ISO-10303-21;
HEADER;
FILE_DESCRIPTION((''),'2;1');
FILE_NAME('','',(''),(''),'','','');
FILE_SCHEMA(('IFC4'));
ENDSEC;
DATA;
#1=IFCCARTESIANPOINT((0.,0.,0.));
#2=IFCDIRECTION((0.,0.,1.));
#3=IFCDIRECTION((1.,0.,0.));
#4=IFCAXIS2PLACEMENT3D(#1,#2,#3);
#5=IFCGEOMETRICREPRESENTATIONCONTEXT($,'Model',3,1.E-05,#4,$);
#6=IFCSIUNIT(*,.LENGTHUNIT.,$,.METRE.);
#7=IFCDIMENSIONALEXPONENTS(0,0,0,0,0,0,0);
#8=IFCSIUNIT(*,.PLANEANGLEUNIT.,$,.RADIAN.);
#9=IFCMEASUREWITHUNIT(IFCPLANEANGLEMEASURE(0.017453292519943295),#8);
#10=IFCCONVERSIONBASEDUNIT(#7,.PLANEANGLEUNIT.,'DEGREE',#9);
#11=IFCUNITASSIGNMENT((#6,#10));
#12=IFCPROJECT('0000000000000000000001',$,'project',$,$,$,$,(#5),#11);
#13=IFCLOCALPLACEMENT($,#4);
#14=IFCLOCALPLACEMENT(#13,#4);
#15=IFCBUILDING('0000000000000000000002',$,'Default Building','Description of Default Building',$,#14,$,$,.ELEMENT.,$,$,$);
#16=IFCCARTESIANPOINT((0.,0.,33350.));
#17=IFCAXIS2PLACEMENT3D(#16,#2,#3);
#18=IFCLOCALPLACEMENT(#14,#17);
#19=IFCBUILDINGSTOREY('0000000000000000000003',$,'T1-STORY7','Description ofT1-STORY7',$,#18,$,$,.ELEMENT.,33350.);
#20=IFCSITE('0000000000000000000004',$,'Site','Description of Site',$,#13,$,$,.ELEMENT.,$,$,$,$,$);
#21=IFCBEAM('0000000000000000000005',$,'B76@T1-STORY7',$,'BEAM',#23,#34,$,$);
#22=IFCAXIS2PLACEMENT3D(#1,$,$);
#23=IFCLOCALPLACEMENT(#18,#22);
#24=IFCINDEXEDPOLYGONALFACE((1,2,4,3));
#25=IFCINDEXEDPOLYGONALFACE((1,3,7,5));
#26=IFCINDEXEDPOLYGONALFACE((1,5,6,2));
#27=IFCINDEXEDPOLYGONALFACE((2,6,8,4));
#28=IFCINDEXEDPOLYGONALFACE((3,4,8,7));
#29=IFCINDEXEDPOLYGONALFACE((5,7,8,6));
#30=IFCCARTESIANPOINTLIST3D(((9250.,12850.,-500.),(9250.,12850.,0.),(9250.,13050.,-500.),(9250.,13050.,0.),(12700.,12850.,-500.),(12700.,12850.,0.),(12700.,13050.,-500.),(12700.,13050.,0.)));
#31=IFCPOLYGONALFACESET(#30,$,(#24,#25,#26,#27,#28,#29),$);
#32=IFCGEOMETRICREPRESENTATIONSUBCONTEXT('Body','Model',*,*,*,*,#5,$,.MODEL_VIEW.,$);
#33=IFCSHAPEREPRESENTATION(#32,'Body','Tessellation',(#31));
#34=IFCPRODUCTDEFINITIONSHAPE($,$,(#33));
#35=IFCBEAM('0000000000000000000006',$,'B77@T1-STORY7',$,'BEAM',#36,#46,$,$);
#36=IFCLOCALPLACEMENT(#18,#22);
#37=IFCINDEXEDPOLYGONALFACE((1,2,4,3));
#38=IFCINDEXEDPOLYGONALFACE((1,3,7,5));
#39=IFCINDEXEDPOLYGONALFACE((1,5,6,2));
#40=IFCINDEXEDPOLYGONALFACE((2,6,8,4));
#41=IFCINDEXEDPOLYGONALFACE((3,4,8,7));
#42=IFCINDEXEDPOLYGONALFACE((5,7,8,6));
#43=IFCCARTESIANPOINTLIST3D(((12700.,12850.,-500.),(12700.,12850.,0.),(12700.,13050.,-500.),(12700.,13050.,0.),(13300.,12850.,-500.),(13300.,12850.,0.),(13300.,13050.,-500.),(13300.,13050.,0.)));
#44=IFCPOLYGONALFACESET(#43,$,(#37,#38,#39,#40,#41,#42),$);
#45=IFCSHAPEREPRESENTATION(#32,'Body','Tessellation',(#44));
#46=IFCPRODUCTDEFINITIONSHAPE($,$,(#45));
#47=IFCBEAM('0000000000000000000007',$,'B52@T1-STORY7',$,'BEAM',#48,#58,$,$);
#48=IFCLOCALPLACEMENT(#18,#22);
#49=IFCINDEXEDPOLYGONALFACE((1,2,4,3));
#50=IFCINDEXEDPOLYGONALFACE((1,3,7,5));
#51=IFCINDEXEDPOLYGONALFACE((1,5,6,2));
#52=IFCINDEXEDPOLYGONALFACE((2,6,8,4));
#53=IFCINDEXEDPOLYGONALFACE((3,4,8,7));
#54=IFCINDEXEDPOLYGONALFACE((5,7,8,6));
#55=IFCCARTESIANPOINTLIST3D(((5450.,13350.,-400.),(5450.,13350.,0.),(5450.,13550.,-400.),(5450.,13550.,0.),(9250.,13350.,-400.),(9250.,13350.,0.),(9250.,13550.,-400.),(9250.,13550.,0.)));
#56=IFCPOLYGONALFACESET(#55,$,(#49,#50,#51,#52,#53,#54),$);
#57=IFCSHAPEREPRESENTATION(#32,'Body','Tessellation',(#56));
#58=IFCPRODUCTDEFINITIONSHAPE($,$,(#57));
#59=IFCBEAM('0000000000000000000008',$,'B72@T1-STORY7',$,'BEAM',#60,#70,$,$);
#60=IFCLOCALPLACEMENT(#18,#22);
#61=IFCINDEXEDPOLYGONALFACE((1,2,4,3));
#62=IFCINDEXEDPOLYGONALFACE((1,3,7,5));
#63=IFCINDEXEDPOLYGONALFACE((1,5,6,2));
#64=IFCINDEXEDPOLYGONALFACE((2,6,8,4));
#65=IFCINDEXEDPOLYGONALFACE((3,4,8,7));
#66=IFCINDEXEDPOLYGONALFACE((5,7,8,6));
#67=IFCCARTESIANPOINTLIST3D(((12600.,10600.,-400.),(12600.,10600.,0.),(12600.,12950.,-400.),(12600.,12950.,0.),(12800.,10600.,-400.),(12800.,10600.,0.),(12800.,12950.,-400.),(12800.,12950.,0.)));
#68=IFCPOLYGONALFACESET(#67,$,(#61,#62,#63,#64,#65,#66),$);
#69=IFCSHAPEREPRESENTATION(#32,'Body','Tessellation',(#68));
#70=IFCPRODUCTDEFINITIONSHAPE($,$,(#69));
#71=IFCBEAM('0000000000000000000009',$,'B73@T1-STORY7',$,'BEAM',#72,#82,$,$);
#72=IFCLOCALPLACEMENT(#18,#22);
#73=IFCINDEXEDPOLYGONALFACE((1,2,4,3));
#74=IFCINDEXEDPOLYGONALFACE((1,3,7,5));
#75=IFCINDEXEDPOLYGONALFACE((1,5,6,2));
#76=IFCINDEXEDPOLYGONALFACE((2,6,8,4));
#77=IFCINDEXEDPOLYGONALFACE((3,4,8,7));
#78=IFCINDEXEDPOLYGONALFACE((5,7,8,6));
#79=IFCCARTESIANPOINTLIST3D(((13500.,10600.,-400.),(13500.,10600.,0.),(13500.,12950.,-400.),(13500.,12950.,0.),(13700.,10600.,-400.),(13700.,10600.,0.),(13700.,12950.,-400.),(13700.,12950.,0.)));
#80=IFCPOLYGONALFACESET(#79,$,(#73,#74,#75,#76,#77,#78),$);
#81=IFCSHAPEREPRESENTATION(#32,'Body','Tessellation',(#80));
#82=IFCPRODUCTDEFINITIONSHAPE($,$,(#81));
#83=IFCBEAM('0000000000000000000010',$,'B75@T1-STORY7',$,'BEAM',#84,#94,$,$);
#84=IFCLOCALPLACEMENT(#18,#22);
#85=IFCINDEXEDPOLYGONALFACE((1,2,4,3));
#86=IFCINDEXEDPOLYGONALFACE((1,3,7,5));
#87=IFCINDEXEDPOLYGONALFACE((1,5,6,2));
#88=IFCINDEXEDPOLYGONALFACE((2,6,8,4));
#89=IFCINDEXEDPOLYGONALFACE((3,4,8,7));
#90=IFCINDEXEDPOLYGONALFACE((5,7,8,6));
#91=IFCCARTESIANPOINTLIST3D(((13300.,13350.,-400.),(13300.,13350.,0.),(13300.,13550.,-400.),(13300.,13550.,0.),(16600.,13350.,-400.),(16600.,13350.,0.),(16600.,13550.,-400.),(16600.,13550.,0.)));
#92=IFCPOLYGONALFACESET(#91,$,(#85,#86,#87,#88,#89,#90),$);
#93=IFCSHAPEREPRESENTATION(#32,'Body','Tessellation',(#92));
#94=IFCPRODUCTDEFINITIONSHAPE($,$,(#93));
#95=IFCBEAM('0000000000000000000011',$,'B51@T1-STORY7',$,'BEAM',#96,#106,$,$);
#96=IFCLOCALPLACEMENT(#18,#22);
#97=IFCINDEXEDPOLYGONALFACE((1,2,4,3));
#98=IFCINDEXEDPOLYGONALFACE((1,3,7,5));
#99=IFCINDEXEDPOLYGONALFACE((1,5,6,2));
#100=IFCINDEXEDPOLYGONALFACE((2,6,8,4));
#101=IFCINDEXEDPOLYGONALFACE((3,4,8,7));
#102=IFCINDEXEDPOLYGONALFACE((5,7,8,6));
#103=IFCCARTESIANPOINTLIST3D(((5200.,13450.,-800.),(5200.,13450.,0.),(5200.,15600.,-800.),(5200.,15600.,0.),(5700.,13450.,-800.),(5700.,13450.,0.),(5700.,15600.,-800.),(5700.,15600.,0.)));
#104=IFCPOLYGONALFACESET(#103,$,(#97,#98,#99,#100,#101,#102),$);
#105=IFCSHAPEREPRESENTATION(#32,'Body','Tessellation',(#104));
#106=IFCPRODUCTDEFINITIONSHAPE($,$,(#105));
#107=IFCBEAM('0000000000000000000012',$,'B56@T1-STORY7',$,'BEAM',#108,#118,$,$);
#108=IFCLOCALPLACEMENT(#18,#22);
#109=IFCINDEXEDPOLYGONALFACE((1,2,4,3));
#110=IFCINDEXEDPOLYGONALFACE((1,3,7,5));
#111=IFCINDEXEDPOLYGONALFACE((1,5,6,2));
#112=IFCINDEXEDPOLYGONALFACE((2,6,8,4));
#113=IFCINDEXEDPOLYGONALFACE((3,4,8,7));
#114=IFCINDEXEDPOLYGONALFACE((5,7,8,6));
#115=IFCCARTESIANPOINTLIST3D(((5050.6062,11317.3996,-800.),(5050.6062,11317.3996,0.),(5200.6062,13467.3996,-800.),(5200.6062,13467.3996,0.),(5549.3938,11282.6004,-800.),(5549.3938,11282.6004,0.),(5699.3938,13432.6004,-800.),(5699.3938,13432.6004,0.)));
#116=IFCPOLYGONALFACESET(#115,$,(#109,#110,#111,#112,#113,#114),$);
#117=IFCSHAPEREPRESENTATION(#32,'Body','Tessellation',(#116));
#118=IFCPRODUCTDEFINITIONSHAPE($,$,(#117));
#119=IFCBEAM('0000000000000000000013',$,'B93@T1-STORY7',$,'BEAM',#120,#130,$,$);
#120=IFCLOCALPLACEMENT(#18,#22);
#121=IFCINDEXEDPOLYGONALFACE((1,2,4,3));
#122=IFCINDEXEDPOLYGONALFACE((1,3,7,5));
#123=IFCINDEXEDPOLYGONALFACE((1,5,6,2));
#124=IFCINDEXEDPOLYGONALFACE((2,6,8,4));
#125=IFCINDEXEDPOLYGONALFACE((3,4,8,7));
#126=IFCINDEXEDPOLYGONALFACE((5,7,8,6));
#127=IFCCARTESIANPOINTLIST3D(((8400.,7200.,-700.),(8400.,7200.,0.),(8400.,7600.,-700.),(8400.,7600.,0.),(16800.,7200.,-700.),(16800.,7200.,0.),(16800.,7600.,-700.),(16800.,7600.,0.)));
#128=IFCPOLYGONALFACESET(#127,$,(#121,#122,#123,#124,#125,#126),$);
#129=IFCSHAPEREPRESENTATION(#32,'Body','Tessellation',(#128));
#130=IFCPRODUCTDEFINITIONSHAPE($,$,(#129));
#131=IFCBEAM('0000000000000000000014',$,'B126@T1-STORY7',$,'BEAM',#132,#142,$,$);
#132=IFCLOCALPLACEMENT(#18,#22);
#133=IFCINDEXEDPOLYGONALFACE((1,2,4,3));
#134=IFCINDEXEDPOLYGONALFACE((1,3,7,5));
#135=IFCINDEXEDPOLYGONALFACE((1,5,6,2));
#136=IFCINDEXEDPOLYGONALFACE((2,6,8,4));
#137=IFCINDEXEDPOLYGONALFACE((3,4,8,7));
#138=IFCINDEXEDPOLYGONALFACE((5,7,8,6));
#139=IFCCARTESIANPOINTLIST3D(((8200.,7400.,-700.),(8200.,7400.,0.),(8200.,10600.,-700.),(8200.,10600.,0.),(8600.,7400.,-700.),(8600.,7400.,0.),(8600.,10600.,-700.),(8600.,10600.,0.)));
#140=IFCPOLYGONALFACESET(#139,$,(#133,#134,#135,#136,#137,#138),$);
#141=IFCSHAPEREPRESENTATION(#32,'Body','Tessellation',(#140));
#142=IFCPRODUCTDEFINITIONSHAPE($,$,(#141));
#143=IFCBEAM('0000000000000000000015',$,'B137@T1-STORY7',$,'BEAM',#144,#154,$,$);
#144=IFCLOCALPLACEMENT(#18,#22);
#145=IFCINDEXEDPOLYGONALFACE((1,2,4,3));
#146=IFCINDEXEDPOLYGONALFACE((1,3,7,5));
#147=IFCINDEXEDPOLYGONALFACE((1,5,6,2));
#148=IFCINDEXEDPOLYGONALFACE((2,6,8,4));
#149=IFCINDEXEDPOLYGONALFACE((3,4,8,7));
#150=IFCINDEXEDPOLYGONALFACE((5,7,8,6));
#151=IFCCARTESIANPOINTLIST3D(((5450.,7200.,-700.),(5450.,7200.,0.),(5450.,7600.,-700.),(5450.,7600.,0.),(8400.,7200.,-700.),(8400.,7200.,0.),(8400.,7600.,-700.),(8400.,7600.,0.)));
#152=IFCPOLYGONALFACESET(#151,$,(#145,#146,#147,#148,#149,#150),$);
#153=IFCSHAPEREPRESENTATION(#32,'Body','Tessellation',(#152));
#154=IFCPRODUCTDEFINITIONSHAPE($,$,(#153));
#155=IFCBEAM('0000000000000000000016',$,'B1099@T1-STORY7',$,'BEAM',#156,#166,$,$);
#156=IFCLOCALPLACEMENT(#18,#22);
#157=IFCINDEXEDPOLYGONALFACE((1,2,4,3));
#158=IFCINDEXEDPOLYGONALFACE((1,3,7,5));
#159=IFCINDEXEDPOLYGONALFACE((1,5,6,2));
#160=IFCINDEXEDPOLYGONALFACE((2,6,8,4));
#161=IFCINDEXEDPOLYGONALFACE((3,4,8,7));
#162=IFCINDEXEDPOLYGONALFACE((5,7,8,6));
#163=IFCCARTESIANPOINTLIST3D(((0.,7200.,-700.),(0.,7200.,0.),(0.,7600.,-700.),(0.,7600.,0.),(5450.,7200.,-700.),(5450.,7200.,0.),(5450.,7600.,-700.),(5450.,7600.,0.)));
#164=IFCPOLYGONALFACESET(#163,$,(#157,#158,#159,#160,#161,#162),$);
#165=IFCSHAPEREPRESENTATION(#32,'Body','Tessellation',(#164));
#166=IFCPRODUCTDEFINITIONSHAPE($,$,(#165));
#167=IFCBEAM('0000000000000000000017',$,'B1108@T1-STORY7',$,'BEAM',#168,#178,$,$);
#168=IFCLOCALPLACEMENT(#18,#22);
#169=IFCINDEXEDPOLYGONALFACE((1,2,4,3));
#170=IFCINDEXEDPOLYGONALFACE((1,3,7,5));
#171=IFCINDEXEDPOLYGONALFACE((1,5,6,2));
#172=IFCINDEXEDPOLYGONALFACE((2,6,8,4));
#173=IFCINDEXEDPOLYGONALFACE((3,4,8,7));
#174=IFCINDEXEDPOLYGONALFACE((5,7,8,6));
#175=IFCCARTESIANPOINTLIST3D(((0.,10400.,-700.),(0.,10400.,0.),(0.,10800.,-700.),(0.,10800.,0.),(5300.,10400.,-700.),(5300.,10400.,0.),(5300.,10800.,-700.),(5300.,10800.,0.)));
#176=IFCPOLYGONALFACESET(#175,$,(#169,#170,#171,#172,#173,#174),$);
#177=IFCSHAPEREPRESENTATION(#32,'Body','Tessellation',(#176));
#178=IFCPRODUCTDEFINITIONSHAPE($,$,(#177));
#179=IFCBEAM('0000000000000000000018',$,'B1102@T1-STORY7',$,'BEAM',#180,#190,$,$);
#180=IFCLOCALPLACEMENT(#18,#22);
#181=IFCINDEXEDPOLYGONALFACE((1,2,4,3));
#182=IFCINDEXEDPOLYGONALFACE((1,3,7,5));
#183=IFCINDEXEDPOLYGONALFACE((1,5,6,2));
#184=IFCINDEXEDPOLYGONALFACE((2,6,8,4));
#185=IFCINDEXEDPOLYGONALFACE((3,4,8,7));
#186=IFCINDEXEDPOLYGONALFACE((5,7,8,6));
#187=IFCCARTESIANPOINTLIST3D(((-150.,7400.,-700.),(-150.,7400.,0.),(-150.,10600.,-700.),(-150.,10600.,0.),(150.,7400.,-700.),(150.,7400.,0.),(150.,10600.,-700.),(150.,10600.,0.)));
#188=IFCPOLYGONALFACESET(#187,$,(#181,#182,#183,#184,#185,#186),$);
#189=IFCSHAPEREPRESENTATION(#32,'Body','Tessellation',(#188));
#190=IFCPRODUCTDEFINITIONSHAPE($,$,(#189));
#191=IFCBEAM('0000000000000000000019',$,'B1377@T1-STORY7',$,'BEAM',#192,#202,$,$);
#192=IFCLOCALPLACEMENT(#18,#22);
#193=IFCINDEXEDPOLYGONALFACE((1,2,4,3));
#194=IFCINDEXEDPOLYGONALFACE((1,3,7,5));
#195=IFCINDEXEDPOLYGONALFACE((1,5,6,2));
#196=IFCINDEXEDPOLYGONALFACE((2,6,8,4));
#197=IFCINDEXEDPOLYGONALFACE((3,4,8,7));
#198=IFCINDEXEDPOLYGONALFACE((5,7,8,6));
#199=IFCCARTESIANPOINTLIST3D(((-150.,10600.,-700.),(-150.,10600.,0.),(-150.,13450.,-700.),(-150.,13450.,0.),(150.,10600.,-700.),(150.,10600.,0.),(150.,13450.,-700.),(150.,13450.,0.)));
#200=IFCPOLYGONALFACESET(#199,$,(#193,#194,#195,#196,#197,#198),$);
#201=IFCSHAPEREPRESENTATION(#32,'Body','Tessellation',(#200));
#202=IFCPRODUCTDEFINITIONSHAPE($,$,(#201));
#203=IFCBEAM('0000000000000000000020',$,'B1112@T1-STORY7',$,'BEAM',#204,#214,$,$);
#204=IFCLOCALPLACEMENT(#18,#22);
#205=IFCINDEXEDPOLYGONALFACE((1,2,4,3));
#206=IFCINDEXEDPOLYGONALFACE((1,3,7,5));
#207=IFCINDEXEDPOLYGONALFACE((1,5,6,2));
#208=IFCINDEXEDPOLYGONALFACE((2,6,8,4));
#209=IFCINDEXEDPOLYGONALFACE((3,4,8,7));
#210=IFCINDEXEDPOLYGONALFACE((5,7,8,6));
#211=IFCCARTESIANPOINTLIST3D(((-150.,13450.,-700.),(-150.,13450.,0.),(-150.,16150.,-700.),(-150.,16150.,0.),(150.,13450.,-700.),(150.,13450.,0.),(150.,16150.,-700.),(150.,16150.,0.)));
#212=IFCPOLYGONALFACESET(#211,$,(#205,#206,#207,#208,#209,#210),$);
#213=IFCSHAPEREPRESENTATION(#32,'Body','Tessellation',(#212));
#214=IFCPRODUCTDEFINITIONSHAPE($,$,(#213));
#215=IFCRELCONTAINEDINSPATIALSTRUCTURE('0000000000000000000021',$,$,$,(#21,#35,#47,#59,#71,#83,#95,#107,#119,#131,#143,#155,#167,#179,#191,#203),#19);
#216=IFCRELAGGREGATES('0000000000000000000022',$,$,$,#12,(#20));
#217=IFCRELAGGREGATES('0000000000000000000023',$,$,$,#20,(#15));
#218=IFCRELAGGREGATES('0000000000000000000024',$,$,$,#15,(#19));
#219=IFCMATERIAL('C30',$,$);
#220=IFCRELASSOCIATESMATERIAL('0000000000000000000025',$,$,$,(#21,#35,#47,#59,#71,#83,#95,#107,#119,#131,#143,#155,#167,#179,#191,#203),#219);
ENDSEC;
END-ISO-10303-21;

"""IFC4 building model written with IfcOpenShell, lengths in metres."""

from ifc_helpers import new_model, entity, si_unit, converted_unit, frame, origin_with_axes, place, context, subcontext, project, spatial, rectangle, extrude, material, element, save


model = new_model("IFC4")

# Units and contexts
model_context = context("Model", 3, precision=1e-05, world=origin_with_axes())
body_context = subcontext(model_context, "Body", "Model", "MODEL_VIEW")
ifc_project = project(units=[si_unit("LENGTHUNIT", "METRE"), converted_unit("PLANEANGLEUNIT", "DEGREE", entity("IfcPlaneAngleMeasure", 0.017453292519943295), si_unit("PLANEANGLEUNIT", "RADIAN"), dimensions=[0, 0, 0, 0, 0, 0, 0])], contexts=[model_context])

# Site, building, storey
site_placement = place(None, origin_with_axes())
site = spatial("IfcSite", under=ifc_project, at=site_placement, Name="Site", Description="Description of Site", CompositionType="ELEMENT")
building_placement = place(site_placement, origin_with_axes())
building = spatial("IfcBuilding", under=site, at=building_placement, Name="Default Building", Description="Description of Default Building", CompositionType="ELEMENT")
storey_placement = place(building_placement, frame((0.0, 0.0, 33350.0), z_axis=(0.0, 0.0, 1.0), x_axis=(1.0, 0.0, 0.0)))
storey = spatial("IfcBuildingStorey", under=building, at=storey_placement, Name="T1-STORY7", Description="Description ofT1-STORY7", CompositionType="ELEMENT", Elevation=33350.0)

# Beams
ifc_material_1 = material(Name="C30")
beam_1_placement = place(storey_placement, frame((9250.0, 12950.0, -250.0), z_axis=(1.0, 0.0, 0.0), x_axis=(0.0, 1.0, 0.0)))
element("IfcBeam", 1, at=beam_1_placement, inside=storey, material=ifc_material_1, Name="B76@T1-STORY7", ObjectType="BEAM", context=body_context, shape_type="SweptSolid", body=[
    extrude(rectangle(XDim=200.0, YDim=500.0), origin_with_axes(), (0.0, 0.0, 1.0), 3450.0),
])
beam_2_placement = place(storey_placement, frame((12700.0, 12950.0, -250.0), z_axis=(1.0, 0.0, 0.0), x_axis=(0.0, 1.0, 0.0)))
element("IfcBeam", 2, at=beam_2_placement, inside=storey, material=ifc_material_1, Name="B77@T1-STORY7", ObjectType="BEAM", context=body_context, shape_type="SweptSolid", body=[
    extrude(rectangle(XDim=200.0, YDim=500.0), origin_with_axes(), (0.0, 0.0, 1.0), 600.0),
])
beam_3_placement = place(storey_placement, frame((5450.0, 13450.0, -200.0), z_axis=(1.0, 0.0, 0.0), x_axis=(0.0, 1.0, 0.0)))
element("IfcBeam", 3, at=beam_3_placement, inside=storey, material=ifc_material_1, Name="B52@T1-STORY7", ObjectType="BEAM", context=body_context, shape_type="SweptSolid", body=[
    extrude(rectangle(XDim=200.0, YDim=400.0), origin_with_axes(), (0.0, 0.0, 1.0), 3800.0),
])
for number, where, z_axis, x_axis, name in (
    (4, (12700.0, 10600.0, -200.0), (0.0, 1.0, 0.0), (-1.0, 0.0, 0.0), "B72@T1-STORY7"),
    (5, (13600.0, 10600.0, -200.0), (0.0, 1.0, 0.0), (-1.0, 0.0, 0.0), "B73@T1-STORY7"),
):
    element("IfcBeam", number, at=place(storey_placement, frame(where, z_axis=z_axis, x_axis=x_axis)), inside=storey, material=ifc_material_1, Name=name, ObjectType="BEAM", context=body_context, shape_type="SweptSolid", body=[
        extrude(rectangle(XDim=200.0, YDim=400.0), origin_with_axes(), (0.0, 0.0, 1.0), 2350.0),
    ])
beam_4_placement = place(storey_placement, frame((13300.0, 13450.0, -200.0), z_axis=(1.0, 0.0, 0.0), x_axis=(0.0, 1.0, 0.0)))
element("IfcBeam", 6, at=beam_4_placement, inside=storey, material=ifc_material_1, Name="B75@T1-STORY7", ObjectType="BEAM", context=body_context, shape_type="SweptSolid", body=[
    extrude(rectangle(XDim=200.0, YDim=400.0), origin_with_axes(), (0.0, 0.0, 1.0), 3300.0),
])
beam_5_placement = place(storey_placement, frame((5450.0, 13450.0, -400.0), z_axis=(0.0, 1.0, 0.0), x_axis=(-1.0, 0.0, 0.0)))
element("IfcBeam", 7, at=beam_5_placement, inside=storey, material=ifc_material_1, Name="B51@T1-STORY7", ObjectType="BEAM", context=body_context, shape_type="SweptSolid", body=[
    extrude(rectangle(XDim=500.0, YDim=800.0), origin_with_axes(), (0.0, 0.0, 1.0), 2150.0),
])
beam_6_placement = place(storey_placement, frame((5300.0, 11300.0, -400.0), z_axis=(0.069598, 0.997575, 0.0), x_axis=(-0.997575, 0.069598, 0.0)))
element("IfcBeam", 8, at=beam_6_placement, inside=storey, material=ifc_material_1, Name="B56@T1-STORY7", ObjectType="BEAM", context=body_context, shape_type="SweptSolid", body=[
    extrude(rectangle(XDim=500.0, YDim=800.0), origin_with_axes(), (0.0, 0.0, 1.0), 2155.2262),
])
beam_7_placement = place(storey_placement, frame((8400.0, 7400.0, -350.0), z_axis=(1.0, 0.0, 0.0), x_axis=(0.0, 1.0, 0.0)))
element("IfcBeam", 9, at=beam_7_placement, inside=storey, material=ifc_material_1, Name="B93@T1-STORY7", ObjectType="BEAM", context=body_context, shape_type="SweptSolid", body=[
    extrude(rectangle(XDim=400.0, YDim=700.0), origin_with_axes(), (0.0, 0.0, 1.0), 8400.0),
])
beam_8_placement = place(storey_placement, frame((8400.0, 7400.0, -350.0), z_axis=(0.0, 1.0, 0.0), x_axis=(-1.0, 0.0, 0.0)))
element("IfcBeam", 10, at=beam_8_placement, inside=storey, material=ifc_material_1, Name="B126@T1-STORY7", ObjectType="BEAM", context=body_context, shape_type="SweptSolid", body=[
    extrude(rectangle(XDim=400.0, YDim=700.0), origin_with_axes(), (0.0, 0.0, 1.0), 3200.0),
])
beam_9_placement = place(storey_placement, frame((5450.0, 7400.0, -350.0), z_axis=(1.0, 0.0, 0.0), x_axis=(0.0, 1.0, 0.0)))
element("IfcBeam", 11, at=beam_9_placement, inside=storey, material=ifc_material_1, Name="B137@T1-STORY7", ObjectType="BEAM", context=body_context, shape_type="SweptSolid", body=[
    extrude(rectangle(XDim=400.0, YDim=700.0), origin_with_axes(), (0.0, 0.0, 1.0), 2950.0),
])
beam_10_placement = place(storey_placement, frame((0.0, 7400.0, -350.0), z_axis=(1.0, 0.0, 0.0), x_axis=(0.0, 1.0, 0.0)))
element("IfcBeam", 12, at=beam_10_placement, inside=storey, material=ifc_material_1, Name="B1099@T1-STORY7", ObjectType="BEAM", context=body_context, shape_type="SweptSolid", body=[
    extrude(rectangle(XDim=400.0, YDim=700.0), origin_with_axes(), (0.0, 0.0, 1.0), 5450.0),
])
beam_11_placement = place(storey_placement, frame((0.0, 10600.0, -350.0), z_axis=(1.0, 0.0, 0.0), x_axis=(0.0, 1.0, 0.0)))
element("IfcBeam", 13, at=beam_11_placement, inside=storey, material=ifc_material_1, Name="B1108@T1-STORY7", ObjectType="BEAM", context=body_context, shape_type="SweptSolid", body=[
    extrude(rectangle(XDim=400.0, YDim=700.0), origin_with_axes(), (0.0, 0.0, 1.0), 5300.0),
])
beam_12_placement = place(storey_placement, frame((0.0, 7400.0, -350.0), z_axis=(0.0, 1.0, 0.0), x_axis=(-1.0, 0.0, 0.0)))
element("IfcBeam", 14, at=beam_12_placement, inside=storey, material=ifc_material_1, Name="B1102@T1-STORY7", ObjectType="BEAM", context=body_context, shape_type="SweptSolid", body=[
    extrude(rectangle(XDim=300.0, YDim=700.0), origin_with_axes(), (0.0, 0.0, 1.0), 3200.0),
])
beam_13_placement = place(storey_placement, frame((0.0, 10600.0, -350.0), z_axis=(0.0, 1.0, 0.0), x_axis=(-1.0, 0.0, 0.0)))
element("IfcBeam", 15, at=beam_13_placement, inside=storey, material=ifc_material_1, Name="B1377@T1-STORY7", ObjectType="BEAM", context=body_context, shape_type="SweptSolid", body=[
    extrude(rectangle(XDim=300.0, YDim=700.0), origin_with_axes(), (0.0, 0.0, 1.0), 2850.0),
])
beam_14_placement = place(storey_placement, frame((0.0, 13450.0, -350.0), z_axis=(0.0, 1.0, 0.0), x_axis=(-1.0, 0.0, 0.0)))
element("IfcBeam", 16, at=beam_14_placement, inside=storey, material=ifc_material_1, Name="B1112@T1-STORY7", ObjectType="BEAM", context=body_context, shape_type="SweptSolid", body=[
    extrude(rectangle(XDim=300.0, YDim=700.0), origin_with_axes(), (0.0, 0.0, 1.0), 2700.0),
])

save(model, "model.ifc")
